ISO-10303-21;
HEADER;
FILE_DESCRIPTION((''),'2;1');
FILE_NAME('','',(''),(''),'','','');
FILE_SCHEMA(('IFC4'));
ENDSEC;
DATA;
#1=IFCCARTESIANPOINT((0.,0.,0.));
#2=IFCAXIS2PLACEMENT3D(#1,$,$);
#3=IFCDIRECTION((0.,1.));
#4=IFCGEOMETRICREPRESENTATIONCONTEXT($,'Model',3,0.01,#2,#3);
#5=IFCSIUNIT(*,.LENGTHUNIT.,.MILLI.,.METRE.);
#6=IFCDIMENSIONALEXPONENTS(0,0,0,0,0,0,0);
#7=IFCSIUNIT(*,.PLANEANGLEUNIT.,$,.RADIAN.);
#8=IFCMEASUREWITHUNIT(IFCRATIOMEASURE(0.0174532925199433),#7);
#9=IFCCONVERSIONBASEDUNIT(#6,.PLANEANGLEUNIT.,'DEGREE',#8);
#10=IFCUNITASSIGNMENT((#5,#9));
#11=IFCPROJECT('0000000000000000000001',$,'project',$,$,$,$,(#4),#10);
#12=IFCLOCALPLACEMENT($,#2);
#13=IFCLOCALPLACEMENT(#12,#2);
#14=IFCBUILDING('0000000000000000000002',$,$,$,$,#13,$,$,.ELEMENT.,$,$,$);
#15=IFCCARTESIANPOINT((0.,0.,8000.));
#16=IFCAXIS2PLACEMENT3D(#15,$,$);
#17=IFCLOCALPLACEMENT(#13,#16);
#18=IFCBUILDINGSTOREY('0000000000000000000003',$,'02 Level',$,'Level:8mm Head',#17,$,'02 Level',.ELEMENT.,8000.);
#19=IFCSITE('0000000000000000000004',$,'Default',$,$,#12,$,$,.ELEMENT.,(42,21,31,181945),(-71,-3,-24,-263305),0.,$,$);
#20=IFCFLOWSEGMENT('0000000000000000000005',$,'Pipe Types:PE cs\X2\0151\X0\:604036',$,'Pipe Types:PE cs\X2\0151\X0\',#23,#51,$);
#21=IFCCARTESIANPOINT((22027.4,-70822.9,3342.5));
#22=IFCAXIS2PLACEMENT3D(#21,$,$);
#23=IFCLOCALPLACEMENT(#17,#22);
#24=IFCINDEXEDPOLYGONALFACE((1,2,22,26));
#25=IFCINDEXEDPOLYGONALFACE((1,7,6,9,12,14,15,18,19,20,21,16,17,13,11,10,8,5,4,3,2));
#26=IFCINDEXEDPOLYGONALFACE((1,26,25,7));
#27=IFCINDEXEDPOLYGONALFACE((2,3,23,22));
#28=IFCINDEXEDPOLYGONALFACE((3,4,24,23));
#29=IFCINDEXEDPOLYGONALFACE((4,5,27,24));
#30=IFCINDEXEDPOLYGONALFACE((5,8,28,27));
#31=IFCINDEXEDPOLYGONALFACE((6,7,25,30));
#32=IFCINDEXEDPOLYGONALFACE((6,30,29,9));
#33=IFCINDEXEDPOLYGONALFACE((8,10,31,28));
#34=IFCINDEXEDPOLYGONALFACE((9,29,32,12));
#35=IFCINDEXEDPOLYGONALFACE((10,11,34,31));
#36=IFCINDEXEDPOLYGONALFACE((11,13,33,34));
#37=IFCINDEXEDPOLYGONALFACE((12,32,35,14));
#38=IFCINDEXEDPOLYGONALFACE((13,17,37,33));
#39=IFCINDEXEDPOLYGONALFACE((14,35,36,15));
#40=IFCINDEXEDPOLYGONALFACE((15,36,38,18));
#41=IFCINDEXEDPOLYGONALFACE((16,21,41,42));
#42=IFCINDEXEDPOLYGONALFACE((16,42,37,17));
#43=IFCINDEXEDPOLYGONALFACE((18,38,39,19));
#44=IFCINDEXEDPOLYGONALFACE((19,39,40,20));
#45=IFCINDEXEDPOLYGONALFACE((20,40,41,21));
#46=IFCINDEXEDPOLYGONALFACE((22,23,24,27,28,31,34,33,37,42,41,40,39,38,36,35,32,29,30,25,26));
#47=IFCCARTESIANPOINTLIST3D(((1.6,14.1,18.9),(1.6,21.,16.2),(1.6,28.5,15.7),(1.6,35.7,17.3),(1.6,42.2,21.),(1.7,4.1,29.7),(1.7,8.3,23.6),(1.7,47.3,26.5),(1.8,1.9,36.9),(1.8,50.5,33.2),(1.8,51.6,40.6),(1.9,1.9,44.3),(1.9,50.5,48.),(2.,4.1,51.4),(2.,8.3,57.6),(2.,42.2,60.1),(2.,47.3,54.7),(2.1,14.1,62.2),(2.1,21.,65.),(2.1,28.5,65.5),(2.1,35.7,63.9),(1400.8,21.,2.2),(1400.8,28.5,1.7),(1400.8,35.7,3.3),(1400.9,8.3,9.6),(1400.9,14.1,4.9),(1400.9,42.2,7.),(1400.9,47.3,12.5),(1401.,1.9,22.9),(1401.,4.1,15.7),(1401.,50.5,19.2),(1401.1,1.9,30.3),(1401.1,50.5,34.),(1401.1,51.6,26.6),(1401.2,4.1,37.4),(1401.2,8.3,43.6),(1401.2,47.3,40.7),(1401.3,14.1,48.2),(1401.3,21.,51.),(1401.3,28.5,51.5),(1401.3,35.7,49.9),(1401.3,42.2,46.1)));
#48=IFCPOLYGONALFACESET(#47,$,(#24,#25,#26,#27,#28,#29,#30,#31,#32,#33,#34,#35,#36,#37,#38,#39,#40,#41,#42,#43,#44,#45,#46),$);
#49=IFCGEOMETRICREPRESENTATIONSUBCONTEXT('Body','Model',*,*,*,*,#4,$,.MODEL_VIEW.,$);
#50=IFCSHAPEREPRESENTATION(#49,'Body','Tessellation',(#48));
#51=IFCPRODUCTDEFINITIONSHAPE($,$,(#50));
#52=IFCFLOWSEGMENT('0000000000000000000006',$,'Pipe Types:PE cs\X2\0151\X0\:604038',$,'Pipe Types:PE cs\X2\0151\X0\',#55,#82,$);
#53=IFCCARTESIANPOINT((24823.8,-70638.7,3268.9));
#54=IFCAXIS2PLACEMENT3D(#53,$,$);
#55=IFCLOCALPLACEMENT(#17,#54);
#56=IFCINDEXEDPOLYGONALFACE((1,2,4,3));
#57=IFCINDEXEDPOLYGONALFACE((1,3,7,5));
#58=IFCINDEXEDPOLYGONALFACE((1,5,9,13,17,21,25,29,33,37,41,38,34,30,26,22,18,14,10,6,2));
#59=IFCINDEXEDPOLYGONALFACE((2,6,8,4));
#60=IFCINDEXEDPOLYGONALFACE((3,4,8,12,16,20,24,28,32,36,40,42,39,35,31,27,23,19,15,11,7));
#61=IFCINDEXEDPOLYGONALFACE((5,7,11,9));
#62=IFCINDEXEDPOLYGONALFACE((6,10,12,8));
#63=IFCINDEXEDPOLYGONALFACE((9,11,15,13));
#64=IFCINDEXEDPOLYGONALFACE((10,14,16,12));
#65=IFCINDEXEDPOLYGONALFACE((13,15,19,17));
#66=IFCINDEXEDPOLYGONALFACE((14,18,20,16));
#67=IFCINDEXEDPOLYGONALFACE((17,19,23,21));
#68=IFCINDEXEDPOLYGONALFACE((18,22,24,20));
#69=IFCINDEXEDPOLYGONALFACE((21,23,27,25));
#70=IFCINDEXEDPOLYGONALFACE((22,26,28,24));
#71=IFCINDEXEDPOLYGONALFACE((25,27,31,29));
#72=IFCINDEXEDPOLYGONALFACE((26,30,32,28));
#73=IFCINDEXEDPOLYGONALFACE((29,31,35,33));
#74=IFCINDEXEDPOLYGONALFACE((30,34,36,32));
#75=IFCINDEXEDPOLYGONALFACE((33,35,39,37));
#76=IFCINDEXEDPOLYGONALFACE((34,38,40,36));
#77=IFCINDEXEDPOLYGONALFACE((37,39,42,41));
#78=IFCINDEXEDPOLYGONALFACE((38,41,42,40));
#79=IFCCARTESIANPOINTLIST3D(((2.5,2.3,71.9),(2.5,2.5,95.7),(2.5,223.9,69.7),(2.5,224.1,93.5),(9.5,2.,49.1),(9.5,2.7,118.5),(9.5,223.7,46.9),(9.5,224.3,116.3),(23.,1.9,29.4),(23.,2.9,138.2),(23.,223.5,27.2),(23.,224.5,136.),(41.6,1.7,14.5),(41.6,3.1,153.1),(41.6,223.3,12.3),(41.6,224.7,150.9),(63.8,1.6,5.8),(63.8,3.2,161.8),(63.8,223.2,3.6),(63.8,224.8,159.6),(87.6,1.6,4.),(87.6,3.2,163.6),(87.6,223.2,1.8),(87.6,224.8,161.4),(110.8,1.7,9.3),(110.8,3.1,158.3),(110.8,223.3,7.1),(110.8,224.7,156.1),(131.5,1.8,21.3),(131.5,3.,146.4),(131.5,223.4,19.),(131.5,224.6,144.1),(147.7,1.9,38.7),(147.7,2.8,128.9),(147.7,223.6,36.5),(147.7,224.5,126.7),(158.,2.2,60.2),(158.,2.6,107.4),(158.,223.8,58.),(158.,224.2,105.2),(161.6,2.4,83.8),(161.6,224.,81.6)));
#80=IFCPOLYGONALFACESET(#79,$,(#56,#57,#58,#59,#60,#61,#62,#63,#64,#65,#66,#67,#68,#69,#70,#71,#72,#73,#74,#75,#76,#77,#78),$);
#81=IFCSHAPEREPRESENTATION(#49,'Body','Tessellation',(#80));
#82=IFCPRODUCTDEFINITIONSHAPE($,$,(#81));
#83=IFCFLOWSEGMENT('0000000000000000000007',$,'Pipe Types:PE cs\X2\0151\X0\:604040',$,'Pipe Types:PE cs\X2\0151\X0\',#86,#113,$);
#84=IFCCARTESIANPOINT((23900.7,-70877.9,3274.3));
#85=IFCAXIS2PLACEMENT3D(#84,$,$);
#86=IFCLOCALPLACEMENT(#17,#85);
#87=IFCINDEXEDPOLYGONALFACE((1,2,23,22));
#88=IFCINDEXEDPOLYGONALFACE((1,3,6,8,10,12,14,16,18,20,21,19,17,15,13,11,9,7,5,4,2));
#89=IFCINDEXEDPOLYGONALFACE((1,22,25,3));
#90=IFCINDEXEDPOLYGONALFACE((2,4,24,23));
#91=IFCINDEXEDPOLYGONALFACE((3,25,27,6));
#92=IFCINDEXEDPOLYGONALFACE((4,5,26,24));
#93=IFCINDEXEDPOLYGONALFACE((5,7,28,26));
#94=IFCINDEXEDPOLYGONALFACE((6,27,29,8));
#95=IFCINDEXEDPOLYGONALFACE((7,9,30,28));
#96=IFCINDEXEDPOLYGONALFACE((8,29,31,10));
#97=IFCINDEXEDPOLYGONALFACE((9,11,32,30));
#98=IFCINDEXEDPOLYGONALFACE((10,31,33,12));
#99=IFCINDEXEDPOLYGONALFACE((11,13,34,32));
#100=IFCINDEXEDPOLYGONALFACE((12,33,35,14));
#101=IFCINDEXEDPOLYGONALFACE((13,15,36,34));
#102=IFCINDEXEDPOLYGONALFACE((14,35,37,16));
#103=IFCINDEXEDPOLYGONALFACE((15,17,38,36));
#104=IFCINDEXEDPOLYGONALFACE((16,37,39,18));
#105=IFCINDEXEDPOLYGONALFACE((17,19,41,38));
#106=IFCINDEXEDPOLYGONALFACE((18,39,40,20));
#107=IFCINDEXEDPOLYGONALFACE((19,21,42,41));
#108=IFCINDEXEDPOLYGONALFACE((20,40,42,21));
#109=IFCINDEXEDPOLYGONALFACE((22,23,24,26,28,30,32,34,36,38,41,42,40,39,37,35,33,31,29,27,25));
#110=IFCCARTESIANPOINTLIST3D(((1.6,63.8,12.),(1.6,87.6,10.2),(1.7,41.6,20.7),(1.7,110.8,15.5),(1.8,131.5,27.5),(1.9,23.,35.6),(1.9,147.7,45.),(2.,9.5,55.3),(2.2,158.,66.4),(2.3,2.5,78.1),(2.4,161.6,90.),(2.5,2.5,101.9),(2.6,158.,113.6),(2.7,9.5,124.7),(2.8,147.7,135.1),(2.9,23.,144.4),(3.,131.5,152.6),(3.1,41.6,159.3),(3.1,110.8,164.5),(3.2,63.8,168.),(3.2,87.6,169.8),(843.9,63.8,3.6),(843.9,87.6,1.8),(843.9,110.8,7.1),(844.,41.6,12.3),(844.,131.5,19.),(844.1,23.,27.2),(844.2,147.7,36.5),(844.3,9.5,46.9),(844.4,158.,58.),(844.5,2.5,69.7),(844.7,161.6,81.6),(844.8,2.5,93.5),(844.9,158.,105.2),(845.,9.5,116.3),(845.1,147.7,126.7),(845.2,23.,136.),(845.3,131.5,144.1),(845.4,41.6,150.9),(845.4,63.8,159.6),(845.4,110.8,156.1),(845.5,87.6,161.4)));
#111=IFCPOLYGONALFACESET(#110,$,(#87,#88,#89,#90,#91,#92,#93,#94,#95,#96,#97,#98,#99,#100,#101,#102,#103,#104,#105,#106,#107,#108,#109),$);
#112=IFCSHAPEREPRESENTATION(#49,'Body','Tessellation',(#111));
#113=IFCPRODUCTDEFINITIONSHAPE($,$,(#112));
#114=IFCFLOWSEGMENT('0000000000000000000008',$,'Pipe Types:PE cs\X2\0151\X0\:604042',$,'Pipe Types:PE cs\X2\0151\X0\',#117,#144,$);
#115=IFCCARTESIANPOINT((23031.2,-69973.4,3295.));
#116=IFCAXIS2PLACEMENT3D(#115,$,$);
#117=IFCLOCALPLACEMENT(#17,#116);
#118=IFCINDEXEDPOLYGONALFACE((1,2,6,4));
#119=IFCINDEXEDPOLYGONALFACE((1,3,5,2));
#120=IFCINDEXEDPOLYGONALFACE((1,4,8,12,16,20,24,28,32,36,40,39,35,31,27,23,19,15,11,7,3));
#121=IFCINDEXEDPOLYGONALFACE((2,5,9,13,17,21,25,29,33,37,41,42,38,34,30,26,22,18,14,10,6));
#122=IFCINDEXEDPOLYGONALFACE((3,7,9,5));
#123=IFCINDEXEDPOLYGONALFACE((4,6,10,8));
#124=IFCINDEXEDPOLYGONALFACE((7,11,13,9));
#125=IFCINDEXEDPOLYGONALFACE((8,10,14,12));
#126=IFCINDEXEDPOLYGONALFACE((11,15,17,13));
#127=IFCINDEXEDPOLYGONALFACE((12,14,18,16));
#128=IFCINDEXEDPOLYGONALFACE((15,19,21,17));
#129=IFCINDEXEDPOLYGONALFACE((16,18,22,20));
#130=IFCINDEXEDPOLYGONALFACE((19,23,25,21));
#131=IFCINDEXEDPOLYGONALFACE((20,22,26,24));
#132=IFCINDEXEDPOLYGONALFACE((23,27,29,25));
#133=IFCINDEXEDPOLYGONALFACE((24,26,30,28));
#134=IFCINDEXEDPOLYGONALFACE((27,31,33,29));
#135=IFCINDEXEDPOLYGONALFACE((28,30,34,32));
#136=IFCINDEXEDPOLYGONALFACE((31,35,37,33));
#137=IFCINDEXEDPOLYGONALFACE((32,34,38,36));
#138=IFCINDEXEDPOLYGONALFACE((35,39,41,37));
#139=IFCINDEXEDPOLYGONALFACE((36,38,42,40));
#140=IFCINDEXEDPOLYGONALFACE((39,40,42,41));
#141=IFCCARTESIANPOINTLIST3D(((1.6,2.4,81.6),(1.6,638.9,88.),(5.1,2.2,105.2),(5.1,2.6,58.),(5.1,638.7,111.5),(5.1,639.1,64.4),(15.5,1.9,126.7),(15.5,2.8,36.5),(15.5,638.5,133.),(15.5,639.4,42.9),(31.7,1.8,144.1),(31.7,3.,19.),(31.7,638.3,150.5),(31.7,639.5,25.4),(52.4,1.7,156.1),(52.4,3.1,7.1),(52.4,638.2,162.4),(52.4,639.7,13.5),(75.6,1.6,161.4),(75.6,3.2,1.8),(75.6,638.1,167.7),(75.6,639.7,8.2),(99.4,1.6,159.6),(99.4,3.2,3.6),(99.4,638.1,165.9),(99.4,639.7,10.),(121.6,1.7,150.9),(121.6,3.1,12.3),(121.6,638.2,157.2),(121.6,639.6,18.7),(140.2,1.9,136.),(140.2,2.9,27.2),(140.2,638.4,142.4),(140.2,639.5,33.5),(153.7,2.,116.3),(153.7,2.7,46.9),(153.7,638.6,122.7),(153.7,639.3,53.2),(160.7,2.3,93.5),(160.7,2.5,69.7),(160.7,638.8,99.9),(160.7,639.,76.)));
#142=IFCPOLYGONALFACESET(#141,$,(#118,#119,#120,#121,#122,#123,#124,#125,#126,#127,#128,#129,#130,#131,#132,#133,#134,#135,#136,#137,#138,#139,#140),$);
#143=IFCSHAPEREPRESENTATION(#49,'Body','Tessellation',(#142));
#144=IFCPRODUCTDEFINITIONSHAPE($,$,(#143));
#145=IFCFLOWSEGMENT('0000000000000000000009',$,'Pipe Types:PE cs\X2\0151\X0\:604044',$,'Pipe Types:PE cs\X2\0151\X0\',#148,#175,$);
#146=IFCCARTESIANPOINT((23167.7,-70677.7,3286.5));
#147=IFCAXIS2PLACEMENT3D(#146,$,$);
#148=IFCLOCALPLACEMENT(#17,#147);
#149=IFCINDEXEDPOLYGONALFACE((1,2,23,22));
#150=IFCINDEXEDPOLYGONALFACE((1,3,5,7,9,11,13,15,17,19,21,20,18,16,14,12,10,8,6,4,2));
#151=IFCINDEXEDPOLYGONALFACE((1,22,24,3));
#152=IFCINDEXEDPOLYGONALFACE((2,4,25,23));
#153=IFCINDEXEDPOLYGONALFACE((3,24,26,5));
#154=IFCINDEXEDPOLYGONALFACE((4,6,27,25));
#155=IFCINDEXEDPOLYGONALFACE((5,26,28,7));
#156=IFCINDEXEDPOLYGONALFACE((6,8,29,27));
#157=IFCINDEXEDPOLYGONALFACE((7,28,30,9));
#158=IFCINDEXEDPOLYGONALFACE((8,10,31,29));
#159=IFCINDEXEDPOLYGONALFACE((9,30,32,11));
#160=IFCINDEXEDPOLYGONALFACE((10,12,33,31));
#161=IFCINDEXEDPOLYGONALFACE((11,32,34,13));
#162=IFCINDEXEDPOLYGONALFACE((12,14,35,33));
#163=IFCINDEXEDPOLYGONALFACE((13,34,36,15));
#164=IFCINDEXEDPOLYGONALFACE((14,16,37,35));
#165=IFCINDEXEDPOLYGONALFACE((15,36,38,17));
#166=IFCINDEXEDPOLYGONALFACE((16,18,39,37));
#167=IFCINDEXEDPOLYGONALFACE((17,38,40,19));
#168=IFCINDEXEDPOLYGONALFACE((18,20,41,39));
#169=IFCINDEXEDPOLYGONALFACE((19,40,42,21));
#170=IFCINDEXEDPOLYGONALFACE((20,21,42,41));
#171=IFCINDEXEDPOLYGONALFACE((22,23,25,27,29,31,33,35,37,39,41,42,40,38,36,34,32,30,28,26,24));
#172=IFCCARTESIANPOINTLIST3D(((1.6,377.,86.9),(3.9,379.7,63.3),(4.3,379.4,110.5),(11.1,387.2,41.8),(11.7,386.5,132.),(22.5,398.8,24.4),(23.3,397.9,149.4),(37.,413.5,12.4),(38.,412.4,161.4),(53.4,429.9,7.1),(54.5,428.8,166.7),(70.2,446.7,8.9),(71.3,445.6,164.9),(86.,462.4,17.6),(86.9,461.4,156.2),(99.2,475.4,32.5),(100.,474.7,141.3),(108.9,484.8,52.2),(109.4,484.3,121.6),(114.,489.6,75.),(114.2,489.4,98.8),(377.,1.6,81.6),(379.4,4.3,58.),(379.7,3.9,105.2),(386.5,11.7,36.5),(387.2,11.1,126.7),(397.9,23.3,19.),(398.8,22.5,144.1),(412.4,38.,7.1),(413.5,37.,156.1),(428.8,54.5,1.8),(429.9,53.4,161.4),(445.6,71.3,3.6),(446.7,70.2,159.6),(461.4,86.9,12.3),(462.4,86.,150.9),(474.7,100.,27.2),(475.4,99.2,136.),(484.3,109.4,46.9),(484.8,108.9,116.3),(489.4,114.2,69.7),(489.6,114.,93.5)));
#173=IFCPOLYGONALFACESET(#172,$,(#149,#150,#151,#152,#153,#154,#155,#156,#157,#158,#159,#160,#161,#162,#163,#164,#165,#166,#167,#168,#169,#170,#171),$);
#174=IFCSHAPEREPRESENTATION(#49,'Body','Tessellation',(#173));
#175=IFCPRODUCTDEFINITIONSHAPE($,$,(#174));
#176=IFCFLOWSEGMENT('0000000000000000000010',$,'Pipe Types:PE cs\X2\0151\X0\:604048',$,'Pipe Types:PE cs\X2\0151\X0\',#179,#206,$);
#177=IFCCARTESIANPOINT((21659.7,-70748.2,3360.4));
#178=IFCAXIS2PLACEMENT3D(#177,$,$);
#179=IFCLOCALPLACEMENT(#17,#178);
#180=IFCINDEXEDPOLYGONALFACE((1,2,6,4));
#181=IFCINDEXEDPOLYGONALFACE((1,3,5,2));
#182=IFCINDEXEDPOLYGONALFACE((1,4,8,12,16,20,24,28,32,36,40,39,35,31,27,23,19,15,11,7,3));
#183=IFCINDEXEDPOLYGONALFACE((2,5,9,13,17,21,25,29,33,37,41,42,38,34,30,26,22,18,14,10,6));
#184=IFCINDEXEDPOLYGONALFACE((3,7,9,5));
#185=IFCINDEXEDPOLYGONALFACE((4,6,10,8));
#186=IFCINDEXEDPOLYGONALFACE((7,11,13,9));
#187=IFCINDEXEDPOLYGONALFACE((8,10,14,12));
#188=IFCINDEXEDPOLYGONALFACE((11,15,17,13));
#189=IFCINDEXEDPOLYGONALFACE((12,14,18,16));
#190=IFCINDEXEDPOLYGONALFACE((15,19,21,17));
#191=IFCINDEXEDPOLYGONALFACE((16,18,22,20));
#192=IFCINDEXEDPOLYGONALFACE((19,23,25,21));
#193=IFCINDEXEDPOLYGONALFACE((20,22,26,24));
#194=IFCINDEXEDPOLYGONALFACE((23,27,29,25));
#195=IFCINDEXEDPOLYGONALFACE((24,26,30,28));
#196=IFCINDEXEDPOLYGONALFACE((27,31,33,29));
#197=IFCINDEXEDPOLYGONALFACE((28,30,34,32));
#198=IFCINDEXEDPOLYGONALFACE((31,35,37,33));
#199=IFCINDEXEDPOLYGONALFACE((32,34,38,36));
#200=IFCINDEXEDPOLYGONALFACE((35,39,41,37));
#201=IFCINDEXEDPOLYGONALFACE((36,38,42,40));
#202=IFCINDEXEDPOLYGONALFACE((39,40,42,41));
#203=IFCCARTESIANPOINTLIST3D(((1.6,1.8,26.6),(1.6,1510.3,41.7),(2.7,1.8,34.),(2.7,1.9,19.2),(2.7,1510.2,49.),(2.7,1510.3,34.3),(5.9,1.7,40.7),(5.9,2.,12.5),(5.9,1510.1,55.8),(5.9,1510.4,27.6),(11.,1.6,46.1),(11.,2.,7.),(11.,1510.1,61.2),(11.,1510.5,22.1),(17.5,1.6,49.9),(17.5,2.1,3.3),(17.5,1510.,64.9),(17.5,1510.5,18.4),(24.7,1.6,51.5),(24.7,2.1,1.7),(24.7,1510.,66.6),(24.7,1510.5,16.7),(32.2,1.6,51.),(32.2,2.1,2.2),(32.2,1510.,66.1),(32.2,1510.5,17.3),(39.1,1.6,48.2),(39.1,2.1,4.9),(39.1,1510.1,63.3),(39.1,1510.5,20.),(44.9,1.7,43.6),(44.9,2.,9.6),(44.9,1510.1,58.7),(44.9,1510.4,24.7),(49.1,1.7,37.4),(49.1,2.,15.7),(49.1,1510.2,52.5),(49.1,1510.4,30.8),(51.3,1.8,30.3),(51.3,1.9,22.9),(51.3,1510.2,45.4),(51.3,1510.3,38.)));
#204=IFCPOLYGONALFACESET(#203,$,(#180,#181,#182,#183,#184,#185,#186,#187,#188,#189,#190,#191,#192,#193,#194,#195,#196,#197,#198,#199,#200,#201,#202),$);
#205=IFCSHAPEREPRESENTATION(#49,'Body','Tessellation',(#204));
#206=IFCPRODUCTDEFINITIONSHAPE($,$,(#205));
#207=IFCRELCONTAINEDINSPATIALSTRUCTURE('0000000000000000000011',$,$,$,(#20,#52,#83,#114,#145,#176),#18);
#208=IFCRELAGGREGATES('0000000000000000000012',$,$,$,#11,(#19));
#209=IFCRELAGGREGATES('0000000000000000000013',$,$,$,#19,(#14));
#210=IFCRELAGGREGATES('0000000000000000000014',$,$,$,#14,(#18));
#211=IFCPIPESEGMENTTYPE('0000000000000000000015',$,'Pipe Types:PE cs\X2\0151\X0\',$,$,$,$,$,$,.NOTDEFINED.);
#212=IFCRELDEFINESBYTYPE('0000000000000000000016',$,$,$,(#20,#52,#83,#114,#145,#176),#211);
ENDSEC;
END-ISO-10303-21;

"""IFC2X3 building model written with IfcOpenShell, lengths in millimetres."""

from ifc_helpers import new_model, entity, si_unit, converted_unit, direction, frame, frame_2d, origin, origin_2d_with_axis, place, context, subcontext, project, spatial, circle, extrude, type_object, element, save


model = new_model("IFC2X3")

# Units and contexts
model_context = context("Model", 3, precision=0.01, world=origin(), true_north=direction((0.0, 1.0)))
body_context = subcontext(model_context, "Body", "Model", "MODEL_VIEW")
ifc_project = project(units=[si_unit("LENGTHUNIT", "METRE", prefix="MILLI"), converted_unit("PLANEANGLEUNIT", "DEGREE", entity("IfcRatioMeasure", 0.0174532925199433), si_unit("PLANEANGLEUNIT", "RADIAN"), dimensions=[0, 0, 0, 0, 0, 0, 0])], contexts=[model_context])

# Site, building, storey
site_placement = place(None, origin())
site = spatial("IfcSite", under=ifc_project, at=site_placement, Name="Default", CompositionType="ELEMENT", RefLatitude=(42, 21, 31, 181945), RefLongitude=(-71, -3, -24, -263305), RefElevation=0.0)
building_placement = place(site_placement, origin())
building = spatial("IfcBuilding", under=site, at=building_placement, CompositionType="ELEMENT")
storey_placement = place(building_placement, frame((0.0, 0.0, 8000.0)))
storey = spatial("IfcBuildingStorey", under=building, at=storey_placement, Name="02 Level", ObjectType="Level:8mm Head", LongName="02 Level", CompositionType="ELEMENT", Elevation=8000.0)

# Flow segments
pipe_segment_type = type_object("IfcPipeSegmentType", Name="Pipe Types:PE cső", PredefinedType="NOTDEFINED")
flow_segment_1_placement = place(storey_placement, frame((22027.4, -70822.9, 3342.5)))
element("IfcFlowSegment", 1, at=flow_segment_1_placement, inside=storey, type_object=pipe_segment_type, Name="Pipe Types:PE cső:604036", ObjectType="Pipe Types:PE cső", context=body_context, shape_type="SweptSolid", body=[
    extrude(circle(Radius=25.0, at=frame_2d((0.0, 0.0), x_axis=(1.0, 0.0))), frame((1.8, 26.6, 40.6), z_axis=(0.99995, 0.0, -0.01), x_axis=(0.0, 1.0, 0.0)), (0.0, 0.0, 1.0), 1399.3),
])
flow_segment_2_placement = place(storey_placement, frame((24823.8, -70638.7, 3268.9)))
element("IfcFlowSegment", 2, at=flow_segment_2_placement, inside=storey, type_object=pipe_segment_type, Name="Pipe Types:PE cső:604038", ObjectType="Pipe Types:PE cső", context=body_context, shape_type="SweptSolid", body=[
    extrude(circle(Radius=80.0, at=frame_2d((0.0, 0.0), x_axis=(1.0, 0.0))), frame((81.6, 2.4, 83.8), z_axis=(0.0, 0.99995, -0.01), x_axis=(1.0, 0.0, 0.0)), (0.0, 0.0, 1.0), 221.6),
])
flow_segment_3_placement = place(storey_placement, frame((23900.7, -70877.9, 3274.3)))
element("IfcFlowSegment", 3, at=flow_segment_3_placement, inside=storey, type_object=pipe_segment_type, Name="Pipe Types:PE cső:604040", ObjectType="Pipe Types:PE cső", context=body_context, shape_type="SweptSolid", body=[
    extrude(circle(Radius=80.0, at=origin_2d_with_axis()), frame((2.4, 81.6, 90.0), z_axis=(0.99995, 0.0, -0.01), x_axis=(0.0, 1.0, 0.0)), (0.0, 0.0, 1.0), 842.3),
])
flow_segment_4_placement = place(storey_placement, frame((23031.2, -69973.4, 3295.0)))
element("IfcFlowSegment", 4, at=flow_segment_4_placement, inside=storey, type_object=pipe_segment_type, Name="Pipe Types:PE cső:604042", ObjectType="Pipe Types:PE cső", context=body_context, shape_type="SweptSolid", body=[
    extrude(circle(Radius=80.0, at=origin_2d_with_axis()), frame((81.6, 2.4, 81.6), z_axis=(0.0, 0.99995, 0.01), x_axis=(-1.0, 0.0, 0.0)), (0.0, 0.0, 1.0), 636.5),
])
flow_segment_5_placement = place(storey_placement, frame((23167.7, -70677.7, 3286.5)))
element("IfcFlowSegment", 5, at=flow_segment_5_placement, inside=storey, type_object=pipe_segment_type, Name="Pipe Types:PE cső:604044", ObjectType="Pipe Types:PE cső", context=body_context, shape_type="SweptSolid", body=[
    extrude(circle(Radius=80.0, at=frame_2d((0.0, 0.0), x_axis=(1.0, 0.0))), frame((58.2, 433.6, 86.9), z_axis=(0.707071, -0.707071, -0.01), x_axis=(-0.707107, -0.707107, 0.0)), (0.0, 0.0, 1.0), 531.0),
])
flow_segment_6_placement = place(storey_placement, frame((21659.7, -70748.2, 3360.4)))
element("IfcFlowSegment", 6, at=flow_segment_6_placement, inside=storey, type_object=pipe_segment_type, Name="Pipe Types:PE cső:604048", ObjectType="Pipe Types:PE cső", context=body_context, shape_type="SweptSolid", body=[
    extrude(circle(Radius=25.0, at=frame_2d((0.0, 0.0), x_axis=(1.0, 0.0))), frame((26.6, 1.8, 26.6), z_axis=(0.0, 0.99995, 0.01), x_axis=(-1.0, 0.0, 0.0)), (0.0, 0.0, 1.0), 1508.5),
])

save(model, "model.ifc")
